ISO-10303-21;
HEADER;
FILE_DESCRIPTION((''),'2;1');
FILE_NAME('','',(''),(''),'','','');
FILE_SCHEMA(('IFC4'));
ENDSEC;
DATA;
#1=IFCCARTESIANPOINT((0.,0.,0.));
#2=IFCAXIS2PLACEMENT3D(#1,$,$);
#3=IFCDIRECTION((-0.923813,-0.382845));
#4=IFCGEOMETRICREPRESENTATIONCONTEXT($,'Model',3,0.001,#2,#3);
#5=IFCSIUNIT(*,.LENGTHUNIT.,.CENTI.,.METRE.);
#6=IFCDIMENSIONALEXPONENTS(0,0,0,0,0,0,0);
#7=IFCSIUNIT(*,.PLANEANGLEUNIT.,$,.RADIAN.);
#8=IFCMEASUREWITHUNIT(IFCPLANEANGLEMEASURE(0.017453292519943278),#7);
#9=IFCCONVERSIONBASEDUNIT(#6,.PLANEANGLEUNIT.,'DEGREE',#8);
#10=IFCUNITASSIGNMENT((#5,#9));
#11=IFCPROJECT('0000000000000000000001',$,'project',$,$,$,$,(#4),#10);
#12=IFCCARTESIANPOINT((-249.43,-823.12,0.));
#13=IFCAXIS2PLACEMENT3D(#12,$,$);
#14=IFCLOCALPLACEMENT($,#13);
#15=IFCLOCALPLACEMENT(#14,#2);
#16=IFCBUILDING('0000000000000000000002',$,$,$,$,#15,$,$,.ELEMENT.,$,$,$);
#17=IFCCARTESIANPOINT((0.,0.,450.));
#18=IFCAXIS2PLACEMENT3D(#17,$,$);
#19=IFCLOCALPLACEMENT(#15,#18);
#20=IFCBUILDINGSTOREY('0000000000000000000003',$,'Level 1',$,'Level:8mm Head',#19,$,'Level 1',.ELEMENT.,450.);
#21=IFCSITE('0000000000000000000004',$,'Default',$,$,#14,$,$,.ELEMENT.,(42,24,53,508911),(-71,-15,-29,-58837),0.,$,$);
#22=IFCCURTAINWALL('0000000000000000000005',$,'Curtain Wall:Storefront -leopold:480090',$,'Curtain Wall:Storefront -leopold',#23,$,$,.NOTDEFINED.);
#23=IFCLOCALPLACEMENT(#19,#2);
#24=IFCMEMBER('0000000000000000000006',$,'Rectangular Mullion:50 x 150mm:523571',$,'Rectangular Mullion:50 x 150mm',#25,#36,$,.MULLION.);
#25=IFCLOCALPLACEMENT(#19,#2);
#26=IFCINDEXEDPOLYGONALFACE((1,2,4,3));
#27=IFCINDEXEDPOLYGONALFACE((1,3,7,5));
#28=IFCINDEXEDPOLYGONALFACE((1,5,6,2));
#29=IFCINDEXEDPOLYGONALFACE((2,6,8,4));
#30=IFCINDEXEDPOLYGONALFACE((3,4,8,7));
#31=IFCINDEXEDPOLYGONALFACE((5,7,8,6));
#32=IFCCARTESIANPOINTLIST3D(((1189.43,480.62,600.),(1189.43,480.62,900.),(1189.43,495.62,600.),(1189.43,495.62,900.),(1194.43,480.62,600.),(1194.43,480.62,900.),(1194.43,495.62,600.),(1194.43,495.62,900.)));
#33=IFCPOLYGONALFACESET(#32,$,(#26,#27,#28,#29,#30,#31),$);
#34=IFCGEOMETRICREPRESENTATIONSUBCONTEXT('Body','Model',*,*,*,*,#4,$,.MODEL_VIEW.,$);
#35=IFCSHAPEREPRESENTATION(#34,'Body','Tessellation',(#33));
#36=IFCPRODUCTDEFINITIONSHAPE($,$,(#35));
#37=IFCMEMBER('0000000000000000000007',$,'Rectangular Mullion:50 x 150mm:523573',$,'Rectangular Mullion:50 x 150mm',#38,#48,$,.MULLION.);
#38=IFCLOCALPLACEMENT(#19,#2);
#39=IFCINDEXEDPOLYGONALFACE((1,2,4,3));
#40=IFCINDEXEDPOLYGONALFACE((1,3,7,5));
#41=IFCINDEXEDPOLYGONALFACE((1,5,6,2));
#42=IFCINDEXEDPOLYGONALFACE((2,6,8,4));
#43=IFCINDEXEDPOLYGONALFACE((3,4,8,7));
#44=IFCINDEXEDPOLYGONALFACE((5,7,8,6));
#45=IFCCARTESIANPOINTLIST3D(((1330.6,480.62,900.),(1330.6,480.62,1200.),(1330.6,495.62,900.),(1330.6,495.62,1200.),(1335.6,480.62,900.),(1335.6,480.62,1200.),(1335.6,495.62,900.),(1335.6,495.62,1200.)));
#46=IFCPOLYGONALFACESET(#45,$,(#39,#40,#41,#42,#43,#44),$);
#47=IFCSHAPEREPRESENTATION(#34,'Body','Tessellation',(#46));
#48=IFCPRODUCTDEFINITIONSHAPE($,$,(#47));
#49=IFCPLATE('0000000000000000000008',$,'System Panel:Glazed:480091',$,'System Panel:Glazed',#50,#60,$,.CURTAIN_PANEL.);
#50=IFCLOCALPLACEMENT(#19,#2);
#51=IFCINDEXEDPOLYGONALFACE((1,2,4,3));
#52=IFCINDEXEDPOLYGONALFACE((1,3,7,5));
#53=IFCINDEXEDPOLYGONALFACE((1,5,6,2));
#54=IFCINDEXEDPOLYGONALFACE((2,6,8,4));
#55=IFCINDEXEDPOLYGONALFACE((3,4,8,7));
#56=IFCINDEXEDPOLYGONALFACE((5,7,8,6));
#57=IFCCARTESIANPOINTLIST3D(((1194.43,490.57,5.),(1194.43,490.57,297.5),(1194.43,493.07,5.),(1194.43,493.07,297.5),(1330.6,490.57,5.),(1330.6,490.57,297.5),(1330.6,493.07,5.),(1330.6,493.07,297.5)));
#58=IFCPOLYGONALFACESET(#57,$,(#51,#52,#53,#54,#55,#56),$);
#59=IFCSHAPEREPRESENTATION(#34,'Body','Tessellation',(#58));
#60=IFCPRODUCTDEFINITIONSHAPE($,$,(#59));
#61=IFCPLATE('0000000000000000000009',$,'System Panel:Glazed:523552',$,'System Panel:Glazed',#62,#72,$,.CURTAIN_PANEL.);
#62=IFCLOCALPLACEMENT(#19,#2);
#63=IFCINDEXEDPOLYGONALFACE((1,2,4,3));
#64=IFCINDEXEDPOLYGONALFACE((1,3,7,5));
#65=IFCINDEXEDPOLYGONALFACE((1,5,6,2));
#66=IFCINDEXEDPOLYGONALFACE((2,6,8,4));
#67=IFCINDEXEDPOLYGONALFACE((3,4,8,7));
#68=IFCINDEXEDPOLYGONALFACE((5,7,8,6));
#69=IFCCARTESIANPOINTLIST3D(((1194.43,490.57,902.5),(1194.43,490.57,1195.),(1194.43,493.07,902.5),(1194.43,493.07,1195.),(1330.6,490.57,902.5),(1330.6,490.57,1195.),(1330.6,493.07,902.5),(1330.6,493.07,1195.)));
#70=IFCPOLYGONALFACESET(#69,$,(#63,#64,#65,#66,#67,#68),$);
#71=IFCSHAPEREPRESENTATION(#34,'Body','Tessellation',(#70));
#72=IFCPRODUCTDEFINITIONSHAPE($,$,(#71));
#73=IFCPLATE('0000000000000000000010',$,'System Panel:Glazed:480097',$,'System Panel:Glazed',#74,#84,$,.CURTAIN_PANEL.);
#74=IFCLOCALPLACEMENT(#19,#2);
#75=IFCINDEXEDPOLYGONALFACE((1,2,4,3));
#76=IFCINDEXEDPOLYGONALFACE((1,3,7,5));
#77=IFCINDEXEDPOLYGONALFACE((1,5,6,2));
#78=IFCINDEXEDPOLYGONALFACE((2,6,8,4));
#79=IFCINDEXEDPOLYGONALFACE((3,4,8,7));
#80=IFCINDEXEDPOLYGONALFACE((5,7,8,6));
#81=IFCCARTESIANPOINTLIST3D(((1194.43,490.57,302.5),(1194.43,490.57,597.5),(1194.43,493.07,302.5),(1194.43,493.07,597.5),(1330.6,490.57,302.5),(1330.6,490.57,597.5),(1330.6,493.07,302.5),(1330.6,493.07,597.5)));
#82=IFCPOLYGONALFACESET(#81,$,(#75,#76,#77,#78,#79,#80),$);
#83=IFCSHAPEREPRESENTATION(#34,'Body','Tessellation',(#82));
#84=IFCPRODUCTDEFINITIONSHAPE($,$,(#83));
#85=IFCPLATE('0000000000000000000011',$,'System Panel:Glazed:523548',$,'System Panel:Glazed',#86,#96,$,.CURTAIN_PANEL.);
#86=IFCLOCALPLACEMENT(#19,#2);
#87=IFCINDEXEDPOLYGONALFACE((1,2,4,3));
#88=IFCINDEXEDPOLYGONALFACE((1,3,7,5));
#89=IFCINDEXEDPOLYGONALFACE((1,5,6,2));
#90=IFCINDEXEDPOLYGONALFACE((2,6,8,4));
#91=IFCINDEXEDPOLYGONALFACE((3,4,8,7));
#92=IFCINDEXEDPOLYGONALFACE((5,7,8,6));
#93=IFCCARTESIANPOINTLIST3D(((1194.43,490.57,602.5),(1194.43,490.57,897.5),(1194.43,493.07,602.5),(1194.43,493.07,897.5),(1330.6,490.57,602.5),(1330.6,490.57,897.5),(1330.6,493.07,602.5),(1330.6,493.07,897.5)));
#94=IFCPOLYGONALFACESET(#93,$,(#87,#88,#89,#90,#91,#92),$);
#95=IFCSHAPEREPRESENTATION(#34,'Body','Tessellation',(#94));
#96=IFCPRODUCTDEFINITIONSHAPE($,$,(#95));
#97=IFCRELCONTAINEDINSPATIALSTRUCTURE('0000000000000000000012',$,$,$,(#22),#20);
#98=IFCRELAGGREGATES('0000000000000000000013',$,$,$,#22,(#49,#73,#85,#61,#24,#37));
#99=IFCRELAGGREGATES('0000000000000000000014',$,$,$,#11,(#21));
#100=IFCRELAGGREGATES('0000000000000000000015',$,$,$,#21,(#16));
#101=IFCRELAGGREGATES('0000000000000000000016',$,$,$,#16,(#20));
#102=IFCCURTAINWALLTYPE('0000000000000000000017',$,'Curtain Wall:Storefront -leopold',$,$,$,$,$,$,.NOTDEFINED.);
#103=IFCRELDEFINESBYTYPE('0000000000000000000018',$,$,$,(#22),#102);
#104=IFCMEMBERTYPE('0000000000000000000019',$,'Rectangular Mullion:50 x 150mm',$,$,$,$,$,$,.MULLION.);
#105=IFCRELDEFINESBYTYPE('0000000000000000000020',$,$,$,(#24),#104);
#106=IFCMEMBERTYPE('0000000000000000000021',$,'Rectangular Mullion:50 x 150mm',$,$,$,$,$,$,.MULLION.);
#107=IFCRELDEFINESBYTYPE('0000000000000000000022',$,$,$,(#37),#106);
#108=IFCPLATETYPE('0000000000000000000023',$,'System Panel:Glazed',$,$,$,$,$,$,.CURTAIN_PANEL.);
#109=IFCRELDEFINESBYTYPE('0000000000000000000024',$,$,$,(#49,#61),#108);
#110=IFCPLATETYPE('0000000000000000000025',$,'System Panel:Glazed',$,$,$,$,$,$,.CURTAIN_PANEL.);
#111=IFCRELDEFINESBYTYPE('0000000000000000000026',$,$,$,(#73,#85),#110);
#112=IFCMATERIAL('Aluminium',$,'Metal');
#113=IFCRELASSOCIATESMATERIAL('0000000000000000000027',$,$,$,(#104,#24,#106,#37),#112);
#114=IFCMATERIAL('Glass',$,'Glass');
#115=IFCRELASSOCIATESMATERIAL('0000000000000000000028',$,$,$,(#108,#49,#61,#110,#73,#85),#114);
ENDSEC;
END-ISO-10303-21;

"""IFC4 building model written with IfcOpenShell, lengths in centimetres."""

from ifc_helpers import new_model, entity, si_unit, converted_unit, direction, frame, origin, place, context, subcontext, project, spatial, indexed_curve, outline, extrude, source, transform, mapped, material, type_object, type_shapes, element, aggregate, save


model = new_model("IFC4")

# Units and contexts
model_context = context("Model", 3, precision=0.001, world=origin(), true_north=direction((-0.923813, -0.382845)))
body_context = subcontext(model_context, "Body", "Model", "MODEL_VIEW")
ifc_project = project(units=[si_unit("LENGTHUNIT", "METRE", prefix="CENTI"), converted_unit("PLANEANGLEUNIT", "DEGREE", entity("IfcPlaneAngleMeasure", 0.017453292519943278), si_unit("PLANEANGLEUNIT", "RADIAN"), dimensions=[0, 0, 0, 0, 0, 0, 0])], contexts=[model_context])

# Site, building, storey
site_placement = place(None, frame((-249.43, -823.12, 0.0)))
site = spatial("IfcSite", under=ifc_project, at=site_placement, Name="Default", CompositionType="ELEMENT", RefLatitude=(42, 24, 53, 508911), RefLongitude=(-71, -15, -29, -58837), RefElevation=0.0)
building_placement = place(site_placement, origin())
building = spatial("IfcBuilding", under=site, at=building_placement, CompositionType="ELEMENT")
storey_placement = place(building_placement, frame((0.0, 0.0, 450.0)))
storey = spatial("IfcBuildingStorey", under=building, at=storey_placement, Name="Level 1", ObjectType="Level:8mm Head", LongName="Level 1", CompositionType="ELEMENT", Elevation=450.0)

# Curtain wall, members, plates
curtain_wall_type = type_object("IfcCurtainWallType", Name="Curtain Wall:Storefront -leopold", PredefinedType="NOTDEFINED")
curtain_wall_placement = place(storey_placement, frame((0.0, 0.0, -450.0)))
curtain_wall = element("IfcCurtainWall", 1, at=curtain_wall_placement, inside=storey, type_object=curtain_wall_type, Name="Curtain Wall:Storefront -leopold:480090", ObjectType="Curtain Wall:Storefront -leopold", PredefinedType="NOTDEFINED")
ifc_material_1 = material(Name="Aluminium", Category="Metal")
member_type_1 = type_object("IfcMemberType", Name="Rectangular Mullion:50 x 150mm", PredefinedType="MULLION", material=ifc_material_1)
shared_shape_1 = source(origin(), body_context, "Body", "SweptSolid", [
    extrude(outline(indexed_curve([(-2.5, -7.5), (2.5, -7.5), (2.5, 7.5), (-2.5, 7.5), (-2.5, -7.5)], self_intersect=False)), frame((-2.5, 0.0, -300.0), z_axis=(0.0, 0.0, 1.0), x_axis=(-1.0, 0.0, 0.0)), (0.0, 0.0, 1.0), 300.0),
])
type_shapes(member_type_1, [shared_shape_1])
member_1_placement = place(curtain_wall_placement, frame((1189.43, 488.12, 1350.0), z_axis=(0.0, 0.0, 1.0), x_axis=(-1.0, 0.0, 0.0)))
member_1 = element("IfcMember", 2, at=member_1_placement, type_object=member_type_1, material=ifc_material_1, Name="Rectangular Mullion:50 x 150mm:523571", ObjectType="Rectangular Mullion:50 x 150mm", PredefinedType="MULLION", context=body_context, shape_type="MappedRepresentation", body=[
    mapped(shared_shape_1, transform((0.0, 0.0, 0.0), scale=1.0)),
])
member_type_2 = type_object("IfcMemberType", Name="Rectangular Mullion:50 x 150mm", PredefinedType="MULLION", material=ifc_material_1)
shared_shape_2 = source(origin(), body_context, "Body", "SweptSolid", [
    extrude(outline(indexed_curve([(-2.5, -7.5), (2.5, -7.5), (2.5, 7.5), (-2.5, 7.5), (-2.5, -7.5)], self_intersect=False)), frame((0.0, 0.0, -300.0), z_axis=(0.0, 0.0, 1.0), x_axis=(-1.0, 0.0, 0.0)), (0.0, 0.0, 1.0), 300.0),
])
type_shapes(member_type_2, [shared_shape_2])
member_2_placement = place(curtain_wall_placement, frame((1333.1, 488.12, 1350.0), z_axis=(0.0, 0.0, -1.0), x_axis=(1.0, 0.0, 0.0)))
member_2 = element("IfcMember", 3, at=member_2_placement, type_object=member_type_2, material=ifc_material_1, Name="Rectangular Mullion:50 x 150mm:523573", ObjectType="Rectangular Mullion:50 x 150mm", PredefinedType="MULLION", context=body_context, shape_type="MappedRepresentation", body=[
    mapped(shared_shape_2, transform((0.0, 0.0, 0.0), scale=1.0)),
])
ifc_material_2 = material(Name="Glass", Category="Glass")
plate_type_1 = type_object("IfcPlateType", Name="System Panel:Glazed", PredefinedType="CURTAIN_PANEL", material=ifc_material_2)
shared_shape_3 = source(origin(), body_context, "Body", "SweptSolid", [
    extrude(outline(indexed_curve([(-1.25, -68.08), (1.25, -68.08), (1.25, 68.08), (-1.25, 68.08), (-1.25, -68.08)], self_intersect=False)), frame((68.08, 1.25, 0.0), z_axis=(0.0, 0.0, 1.0), x_axis=(0.0, 1.0, 0.0)), (0.0, 0.0, 1.0), 292.5),
])
type_shapes(plate_type_1, [shared_shape_3])
plate_1_placement = place(curtain_wall_placement, frame((1194.43, 490.57, 455.0)))
plate_1 = element("IfcPlate", 4, at=plate_1_placement, type_object=plate_type_1, material=ifc_material_2, Name="System Panel:Glazed:480091", ObjectType="System Panel:Glazed", PredefinedType="CURTAIN_PANEL", context=body_context, shape_type="MappedRepresentation", body=[
    mapped(shared_shape_3, transform((0.0, 0.0, 0.0), scale=1.0)),
])
plate_2_placement = place(curtain_wall_placement, frame((1194.43, 490.57, 1352.5)))
plate_2 = element("IfcPlate", 5, at=plate_2_placement, type_object=plate_type_1, material=ifc_material_2, Name="System Panel:Glazed:523552", ObjectType="System Panel:Glazed", PredefinedType="CURTAIN_PANEL", context=body_context, shape_type="MappedRepresentation", body=[
    mapped(shared_shape_3, transform((0.0, 0.0, 0.0), scale=1.0)),
])
plate_type_2 = type_object("IfcPlateType", Name="System Panel:Glazed", PredefinedType="CURTAIN_PANEL", material=ifc_material_2)
shared_shape_4 = source(origin(), body_context, "Body", "SweptSolid", [
    extrude(outline(indexed_curve([(-1.25, -68.08), (1.25, -68.08), (1.25, 68.08), (-1.25, 68.08), (-1.25, -68.08)], self_intersect=False)), frame((68.08, 1.25, 0.0), z_axis=(0.0, 0.0, 1.0), x_axis=(0.0, 1.0, 0.0)), (0.0, 0.0, 1.0), 295.0),
])
type_shapes(plate_type_2, [shared_shape_4])
plate_3_placement = place(curtain_wall_placement, frame((1194.43, 490.57, 752.5)))
plate_3 = element("IfcPlate", 6, at=plate_3_placement, type_object=plate_type_2, material=ifc_material_2, Name="System Panel:Glazed:480097", ObjectType="System Panel:Glazed", PredefinedType="CURTAIN_PANEL", context=body_context, shape_type="MappedRepresentation", body=[
    mapped(shared_shape_4, transform((0.0, 0.0, 0.0), scale=1.0)),
])
plate_4_placement = place(curtain_wall_placement, frame((1194.43, 490.57, 1052.5)))
plate_4 = element("IfcPlate", 7, at=plate_4_placement, type_object=plate_type_2, material=ifc_material_2, Name="System Panel:Glazed:523548", ObjectType="System Panel:Glazed", PredefinedType="CURTAIN_PANEL", context=body_context, shape_type="MappedRepresentation", body=[
    mapped(shared_shape_4, transform((0.0, 0.0, 0.0), scale=1.0)),
])
aggregate(curtain_wall, [plate_1, plate_3, plate_4, plate_2, member_1, member_2])

save(model, "model.ifc")
